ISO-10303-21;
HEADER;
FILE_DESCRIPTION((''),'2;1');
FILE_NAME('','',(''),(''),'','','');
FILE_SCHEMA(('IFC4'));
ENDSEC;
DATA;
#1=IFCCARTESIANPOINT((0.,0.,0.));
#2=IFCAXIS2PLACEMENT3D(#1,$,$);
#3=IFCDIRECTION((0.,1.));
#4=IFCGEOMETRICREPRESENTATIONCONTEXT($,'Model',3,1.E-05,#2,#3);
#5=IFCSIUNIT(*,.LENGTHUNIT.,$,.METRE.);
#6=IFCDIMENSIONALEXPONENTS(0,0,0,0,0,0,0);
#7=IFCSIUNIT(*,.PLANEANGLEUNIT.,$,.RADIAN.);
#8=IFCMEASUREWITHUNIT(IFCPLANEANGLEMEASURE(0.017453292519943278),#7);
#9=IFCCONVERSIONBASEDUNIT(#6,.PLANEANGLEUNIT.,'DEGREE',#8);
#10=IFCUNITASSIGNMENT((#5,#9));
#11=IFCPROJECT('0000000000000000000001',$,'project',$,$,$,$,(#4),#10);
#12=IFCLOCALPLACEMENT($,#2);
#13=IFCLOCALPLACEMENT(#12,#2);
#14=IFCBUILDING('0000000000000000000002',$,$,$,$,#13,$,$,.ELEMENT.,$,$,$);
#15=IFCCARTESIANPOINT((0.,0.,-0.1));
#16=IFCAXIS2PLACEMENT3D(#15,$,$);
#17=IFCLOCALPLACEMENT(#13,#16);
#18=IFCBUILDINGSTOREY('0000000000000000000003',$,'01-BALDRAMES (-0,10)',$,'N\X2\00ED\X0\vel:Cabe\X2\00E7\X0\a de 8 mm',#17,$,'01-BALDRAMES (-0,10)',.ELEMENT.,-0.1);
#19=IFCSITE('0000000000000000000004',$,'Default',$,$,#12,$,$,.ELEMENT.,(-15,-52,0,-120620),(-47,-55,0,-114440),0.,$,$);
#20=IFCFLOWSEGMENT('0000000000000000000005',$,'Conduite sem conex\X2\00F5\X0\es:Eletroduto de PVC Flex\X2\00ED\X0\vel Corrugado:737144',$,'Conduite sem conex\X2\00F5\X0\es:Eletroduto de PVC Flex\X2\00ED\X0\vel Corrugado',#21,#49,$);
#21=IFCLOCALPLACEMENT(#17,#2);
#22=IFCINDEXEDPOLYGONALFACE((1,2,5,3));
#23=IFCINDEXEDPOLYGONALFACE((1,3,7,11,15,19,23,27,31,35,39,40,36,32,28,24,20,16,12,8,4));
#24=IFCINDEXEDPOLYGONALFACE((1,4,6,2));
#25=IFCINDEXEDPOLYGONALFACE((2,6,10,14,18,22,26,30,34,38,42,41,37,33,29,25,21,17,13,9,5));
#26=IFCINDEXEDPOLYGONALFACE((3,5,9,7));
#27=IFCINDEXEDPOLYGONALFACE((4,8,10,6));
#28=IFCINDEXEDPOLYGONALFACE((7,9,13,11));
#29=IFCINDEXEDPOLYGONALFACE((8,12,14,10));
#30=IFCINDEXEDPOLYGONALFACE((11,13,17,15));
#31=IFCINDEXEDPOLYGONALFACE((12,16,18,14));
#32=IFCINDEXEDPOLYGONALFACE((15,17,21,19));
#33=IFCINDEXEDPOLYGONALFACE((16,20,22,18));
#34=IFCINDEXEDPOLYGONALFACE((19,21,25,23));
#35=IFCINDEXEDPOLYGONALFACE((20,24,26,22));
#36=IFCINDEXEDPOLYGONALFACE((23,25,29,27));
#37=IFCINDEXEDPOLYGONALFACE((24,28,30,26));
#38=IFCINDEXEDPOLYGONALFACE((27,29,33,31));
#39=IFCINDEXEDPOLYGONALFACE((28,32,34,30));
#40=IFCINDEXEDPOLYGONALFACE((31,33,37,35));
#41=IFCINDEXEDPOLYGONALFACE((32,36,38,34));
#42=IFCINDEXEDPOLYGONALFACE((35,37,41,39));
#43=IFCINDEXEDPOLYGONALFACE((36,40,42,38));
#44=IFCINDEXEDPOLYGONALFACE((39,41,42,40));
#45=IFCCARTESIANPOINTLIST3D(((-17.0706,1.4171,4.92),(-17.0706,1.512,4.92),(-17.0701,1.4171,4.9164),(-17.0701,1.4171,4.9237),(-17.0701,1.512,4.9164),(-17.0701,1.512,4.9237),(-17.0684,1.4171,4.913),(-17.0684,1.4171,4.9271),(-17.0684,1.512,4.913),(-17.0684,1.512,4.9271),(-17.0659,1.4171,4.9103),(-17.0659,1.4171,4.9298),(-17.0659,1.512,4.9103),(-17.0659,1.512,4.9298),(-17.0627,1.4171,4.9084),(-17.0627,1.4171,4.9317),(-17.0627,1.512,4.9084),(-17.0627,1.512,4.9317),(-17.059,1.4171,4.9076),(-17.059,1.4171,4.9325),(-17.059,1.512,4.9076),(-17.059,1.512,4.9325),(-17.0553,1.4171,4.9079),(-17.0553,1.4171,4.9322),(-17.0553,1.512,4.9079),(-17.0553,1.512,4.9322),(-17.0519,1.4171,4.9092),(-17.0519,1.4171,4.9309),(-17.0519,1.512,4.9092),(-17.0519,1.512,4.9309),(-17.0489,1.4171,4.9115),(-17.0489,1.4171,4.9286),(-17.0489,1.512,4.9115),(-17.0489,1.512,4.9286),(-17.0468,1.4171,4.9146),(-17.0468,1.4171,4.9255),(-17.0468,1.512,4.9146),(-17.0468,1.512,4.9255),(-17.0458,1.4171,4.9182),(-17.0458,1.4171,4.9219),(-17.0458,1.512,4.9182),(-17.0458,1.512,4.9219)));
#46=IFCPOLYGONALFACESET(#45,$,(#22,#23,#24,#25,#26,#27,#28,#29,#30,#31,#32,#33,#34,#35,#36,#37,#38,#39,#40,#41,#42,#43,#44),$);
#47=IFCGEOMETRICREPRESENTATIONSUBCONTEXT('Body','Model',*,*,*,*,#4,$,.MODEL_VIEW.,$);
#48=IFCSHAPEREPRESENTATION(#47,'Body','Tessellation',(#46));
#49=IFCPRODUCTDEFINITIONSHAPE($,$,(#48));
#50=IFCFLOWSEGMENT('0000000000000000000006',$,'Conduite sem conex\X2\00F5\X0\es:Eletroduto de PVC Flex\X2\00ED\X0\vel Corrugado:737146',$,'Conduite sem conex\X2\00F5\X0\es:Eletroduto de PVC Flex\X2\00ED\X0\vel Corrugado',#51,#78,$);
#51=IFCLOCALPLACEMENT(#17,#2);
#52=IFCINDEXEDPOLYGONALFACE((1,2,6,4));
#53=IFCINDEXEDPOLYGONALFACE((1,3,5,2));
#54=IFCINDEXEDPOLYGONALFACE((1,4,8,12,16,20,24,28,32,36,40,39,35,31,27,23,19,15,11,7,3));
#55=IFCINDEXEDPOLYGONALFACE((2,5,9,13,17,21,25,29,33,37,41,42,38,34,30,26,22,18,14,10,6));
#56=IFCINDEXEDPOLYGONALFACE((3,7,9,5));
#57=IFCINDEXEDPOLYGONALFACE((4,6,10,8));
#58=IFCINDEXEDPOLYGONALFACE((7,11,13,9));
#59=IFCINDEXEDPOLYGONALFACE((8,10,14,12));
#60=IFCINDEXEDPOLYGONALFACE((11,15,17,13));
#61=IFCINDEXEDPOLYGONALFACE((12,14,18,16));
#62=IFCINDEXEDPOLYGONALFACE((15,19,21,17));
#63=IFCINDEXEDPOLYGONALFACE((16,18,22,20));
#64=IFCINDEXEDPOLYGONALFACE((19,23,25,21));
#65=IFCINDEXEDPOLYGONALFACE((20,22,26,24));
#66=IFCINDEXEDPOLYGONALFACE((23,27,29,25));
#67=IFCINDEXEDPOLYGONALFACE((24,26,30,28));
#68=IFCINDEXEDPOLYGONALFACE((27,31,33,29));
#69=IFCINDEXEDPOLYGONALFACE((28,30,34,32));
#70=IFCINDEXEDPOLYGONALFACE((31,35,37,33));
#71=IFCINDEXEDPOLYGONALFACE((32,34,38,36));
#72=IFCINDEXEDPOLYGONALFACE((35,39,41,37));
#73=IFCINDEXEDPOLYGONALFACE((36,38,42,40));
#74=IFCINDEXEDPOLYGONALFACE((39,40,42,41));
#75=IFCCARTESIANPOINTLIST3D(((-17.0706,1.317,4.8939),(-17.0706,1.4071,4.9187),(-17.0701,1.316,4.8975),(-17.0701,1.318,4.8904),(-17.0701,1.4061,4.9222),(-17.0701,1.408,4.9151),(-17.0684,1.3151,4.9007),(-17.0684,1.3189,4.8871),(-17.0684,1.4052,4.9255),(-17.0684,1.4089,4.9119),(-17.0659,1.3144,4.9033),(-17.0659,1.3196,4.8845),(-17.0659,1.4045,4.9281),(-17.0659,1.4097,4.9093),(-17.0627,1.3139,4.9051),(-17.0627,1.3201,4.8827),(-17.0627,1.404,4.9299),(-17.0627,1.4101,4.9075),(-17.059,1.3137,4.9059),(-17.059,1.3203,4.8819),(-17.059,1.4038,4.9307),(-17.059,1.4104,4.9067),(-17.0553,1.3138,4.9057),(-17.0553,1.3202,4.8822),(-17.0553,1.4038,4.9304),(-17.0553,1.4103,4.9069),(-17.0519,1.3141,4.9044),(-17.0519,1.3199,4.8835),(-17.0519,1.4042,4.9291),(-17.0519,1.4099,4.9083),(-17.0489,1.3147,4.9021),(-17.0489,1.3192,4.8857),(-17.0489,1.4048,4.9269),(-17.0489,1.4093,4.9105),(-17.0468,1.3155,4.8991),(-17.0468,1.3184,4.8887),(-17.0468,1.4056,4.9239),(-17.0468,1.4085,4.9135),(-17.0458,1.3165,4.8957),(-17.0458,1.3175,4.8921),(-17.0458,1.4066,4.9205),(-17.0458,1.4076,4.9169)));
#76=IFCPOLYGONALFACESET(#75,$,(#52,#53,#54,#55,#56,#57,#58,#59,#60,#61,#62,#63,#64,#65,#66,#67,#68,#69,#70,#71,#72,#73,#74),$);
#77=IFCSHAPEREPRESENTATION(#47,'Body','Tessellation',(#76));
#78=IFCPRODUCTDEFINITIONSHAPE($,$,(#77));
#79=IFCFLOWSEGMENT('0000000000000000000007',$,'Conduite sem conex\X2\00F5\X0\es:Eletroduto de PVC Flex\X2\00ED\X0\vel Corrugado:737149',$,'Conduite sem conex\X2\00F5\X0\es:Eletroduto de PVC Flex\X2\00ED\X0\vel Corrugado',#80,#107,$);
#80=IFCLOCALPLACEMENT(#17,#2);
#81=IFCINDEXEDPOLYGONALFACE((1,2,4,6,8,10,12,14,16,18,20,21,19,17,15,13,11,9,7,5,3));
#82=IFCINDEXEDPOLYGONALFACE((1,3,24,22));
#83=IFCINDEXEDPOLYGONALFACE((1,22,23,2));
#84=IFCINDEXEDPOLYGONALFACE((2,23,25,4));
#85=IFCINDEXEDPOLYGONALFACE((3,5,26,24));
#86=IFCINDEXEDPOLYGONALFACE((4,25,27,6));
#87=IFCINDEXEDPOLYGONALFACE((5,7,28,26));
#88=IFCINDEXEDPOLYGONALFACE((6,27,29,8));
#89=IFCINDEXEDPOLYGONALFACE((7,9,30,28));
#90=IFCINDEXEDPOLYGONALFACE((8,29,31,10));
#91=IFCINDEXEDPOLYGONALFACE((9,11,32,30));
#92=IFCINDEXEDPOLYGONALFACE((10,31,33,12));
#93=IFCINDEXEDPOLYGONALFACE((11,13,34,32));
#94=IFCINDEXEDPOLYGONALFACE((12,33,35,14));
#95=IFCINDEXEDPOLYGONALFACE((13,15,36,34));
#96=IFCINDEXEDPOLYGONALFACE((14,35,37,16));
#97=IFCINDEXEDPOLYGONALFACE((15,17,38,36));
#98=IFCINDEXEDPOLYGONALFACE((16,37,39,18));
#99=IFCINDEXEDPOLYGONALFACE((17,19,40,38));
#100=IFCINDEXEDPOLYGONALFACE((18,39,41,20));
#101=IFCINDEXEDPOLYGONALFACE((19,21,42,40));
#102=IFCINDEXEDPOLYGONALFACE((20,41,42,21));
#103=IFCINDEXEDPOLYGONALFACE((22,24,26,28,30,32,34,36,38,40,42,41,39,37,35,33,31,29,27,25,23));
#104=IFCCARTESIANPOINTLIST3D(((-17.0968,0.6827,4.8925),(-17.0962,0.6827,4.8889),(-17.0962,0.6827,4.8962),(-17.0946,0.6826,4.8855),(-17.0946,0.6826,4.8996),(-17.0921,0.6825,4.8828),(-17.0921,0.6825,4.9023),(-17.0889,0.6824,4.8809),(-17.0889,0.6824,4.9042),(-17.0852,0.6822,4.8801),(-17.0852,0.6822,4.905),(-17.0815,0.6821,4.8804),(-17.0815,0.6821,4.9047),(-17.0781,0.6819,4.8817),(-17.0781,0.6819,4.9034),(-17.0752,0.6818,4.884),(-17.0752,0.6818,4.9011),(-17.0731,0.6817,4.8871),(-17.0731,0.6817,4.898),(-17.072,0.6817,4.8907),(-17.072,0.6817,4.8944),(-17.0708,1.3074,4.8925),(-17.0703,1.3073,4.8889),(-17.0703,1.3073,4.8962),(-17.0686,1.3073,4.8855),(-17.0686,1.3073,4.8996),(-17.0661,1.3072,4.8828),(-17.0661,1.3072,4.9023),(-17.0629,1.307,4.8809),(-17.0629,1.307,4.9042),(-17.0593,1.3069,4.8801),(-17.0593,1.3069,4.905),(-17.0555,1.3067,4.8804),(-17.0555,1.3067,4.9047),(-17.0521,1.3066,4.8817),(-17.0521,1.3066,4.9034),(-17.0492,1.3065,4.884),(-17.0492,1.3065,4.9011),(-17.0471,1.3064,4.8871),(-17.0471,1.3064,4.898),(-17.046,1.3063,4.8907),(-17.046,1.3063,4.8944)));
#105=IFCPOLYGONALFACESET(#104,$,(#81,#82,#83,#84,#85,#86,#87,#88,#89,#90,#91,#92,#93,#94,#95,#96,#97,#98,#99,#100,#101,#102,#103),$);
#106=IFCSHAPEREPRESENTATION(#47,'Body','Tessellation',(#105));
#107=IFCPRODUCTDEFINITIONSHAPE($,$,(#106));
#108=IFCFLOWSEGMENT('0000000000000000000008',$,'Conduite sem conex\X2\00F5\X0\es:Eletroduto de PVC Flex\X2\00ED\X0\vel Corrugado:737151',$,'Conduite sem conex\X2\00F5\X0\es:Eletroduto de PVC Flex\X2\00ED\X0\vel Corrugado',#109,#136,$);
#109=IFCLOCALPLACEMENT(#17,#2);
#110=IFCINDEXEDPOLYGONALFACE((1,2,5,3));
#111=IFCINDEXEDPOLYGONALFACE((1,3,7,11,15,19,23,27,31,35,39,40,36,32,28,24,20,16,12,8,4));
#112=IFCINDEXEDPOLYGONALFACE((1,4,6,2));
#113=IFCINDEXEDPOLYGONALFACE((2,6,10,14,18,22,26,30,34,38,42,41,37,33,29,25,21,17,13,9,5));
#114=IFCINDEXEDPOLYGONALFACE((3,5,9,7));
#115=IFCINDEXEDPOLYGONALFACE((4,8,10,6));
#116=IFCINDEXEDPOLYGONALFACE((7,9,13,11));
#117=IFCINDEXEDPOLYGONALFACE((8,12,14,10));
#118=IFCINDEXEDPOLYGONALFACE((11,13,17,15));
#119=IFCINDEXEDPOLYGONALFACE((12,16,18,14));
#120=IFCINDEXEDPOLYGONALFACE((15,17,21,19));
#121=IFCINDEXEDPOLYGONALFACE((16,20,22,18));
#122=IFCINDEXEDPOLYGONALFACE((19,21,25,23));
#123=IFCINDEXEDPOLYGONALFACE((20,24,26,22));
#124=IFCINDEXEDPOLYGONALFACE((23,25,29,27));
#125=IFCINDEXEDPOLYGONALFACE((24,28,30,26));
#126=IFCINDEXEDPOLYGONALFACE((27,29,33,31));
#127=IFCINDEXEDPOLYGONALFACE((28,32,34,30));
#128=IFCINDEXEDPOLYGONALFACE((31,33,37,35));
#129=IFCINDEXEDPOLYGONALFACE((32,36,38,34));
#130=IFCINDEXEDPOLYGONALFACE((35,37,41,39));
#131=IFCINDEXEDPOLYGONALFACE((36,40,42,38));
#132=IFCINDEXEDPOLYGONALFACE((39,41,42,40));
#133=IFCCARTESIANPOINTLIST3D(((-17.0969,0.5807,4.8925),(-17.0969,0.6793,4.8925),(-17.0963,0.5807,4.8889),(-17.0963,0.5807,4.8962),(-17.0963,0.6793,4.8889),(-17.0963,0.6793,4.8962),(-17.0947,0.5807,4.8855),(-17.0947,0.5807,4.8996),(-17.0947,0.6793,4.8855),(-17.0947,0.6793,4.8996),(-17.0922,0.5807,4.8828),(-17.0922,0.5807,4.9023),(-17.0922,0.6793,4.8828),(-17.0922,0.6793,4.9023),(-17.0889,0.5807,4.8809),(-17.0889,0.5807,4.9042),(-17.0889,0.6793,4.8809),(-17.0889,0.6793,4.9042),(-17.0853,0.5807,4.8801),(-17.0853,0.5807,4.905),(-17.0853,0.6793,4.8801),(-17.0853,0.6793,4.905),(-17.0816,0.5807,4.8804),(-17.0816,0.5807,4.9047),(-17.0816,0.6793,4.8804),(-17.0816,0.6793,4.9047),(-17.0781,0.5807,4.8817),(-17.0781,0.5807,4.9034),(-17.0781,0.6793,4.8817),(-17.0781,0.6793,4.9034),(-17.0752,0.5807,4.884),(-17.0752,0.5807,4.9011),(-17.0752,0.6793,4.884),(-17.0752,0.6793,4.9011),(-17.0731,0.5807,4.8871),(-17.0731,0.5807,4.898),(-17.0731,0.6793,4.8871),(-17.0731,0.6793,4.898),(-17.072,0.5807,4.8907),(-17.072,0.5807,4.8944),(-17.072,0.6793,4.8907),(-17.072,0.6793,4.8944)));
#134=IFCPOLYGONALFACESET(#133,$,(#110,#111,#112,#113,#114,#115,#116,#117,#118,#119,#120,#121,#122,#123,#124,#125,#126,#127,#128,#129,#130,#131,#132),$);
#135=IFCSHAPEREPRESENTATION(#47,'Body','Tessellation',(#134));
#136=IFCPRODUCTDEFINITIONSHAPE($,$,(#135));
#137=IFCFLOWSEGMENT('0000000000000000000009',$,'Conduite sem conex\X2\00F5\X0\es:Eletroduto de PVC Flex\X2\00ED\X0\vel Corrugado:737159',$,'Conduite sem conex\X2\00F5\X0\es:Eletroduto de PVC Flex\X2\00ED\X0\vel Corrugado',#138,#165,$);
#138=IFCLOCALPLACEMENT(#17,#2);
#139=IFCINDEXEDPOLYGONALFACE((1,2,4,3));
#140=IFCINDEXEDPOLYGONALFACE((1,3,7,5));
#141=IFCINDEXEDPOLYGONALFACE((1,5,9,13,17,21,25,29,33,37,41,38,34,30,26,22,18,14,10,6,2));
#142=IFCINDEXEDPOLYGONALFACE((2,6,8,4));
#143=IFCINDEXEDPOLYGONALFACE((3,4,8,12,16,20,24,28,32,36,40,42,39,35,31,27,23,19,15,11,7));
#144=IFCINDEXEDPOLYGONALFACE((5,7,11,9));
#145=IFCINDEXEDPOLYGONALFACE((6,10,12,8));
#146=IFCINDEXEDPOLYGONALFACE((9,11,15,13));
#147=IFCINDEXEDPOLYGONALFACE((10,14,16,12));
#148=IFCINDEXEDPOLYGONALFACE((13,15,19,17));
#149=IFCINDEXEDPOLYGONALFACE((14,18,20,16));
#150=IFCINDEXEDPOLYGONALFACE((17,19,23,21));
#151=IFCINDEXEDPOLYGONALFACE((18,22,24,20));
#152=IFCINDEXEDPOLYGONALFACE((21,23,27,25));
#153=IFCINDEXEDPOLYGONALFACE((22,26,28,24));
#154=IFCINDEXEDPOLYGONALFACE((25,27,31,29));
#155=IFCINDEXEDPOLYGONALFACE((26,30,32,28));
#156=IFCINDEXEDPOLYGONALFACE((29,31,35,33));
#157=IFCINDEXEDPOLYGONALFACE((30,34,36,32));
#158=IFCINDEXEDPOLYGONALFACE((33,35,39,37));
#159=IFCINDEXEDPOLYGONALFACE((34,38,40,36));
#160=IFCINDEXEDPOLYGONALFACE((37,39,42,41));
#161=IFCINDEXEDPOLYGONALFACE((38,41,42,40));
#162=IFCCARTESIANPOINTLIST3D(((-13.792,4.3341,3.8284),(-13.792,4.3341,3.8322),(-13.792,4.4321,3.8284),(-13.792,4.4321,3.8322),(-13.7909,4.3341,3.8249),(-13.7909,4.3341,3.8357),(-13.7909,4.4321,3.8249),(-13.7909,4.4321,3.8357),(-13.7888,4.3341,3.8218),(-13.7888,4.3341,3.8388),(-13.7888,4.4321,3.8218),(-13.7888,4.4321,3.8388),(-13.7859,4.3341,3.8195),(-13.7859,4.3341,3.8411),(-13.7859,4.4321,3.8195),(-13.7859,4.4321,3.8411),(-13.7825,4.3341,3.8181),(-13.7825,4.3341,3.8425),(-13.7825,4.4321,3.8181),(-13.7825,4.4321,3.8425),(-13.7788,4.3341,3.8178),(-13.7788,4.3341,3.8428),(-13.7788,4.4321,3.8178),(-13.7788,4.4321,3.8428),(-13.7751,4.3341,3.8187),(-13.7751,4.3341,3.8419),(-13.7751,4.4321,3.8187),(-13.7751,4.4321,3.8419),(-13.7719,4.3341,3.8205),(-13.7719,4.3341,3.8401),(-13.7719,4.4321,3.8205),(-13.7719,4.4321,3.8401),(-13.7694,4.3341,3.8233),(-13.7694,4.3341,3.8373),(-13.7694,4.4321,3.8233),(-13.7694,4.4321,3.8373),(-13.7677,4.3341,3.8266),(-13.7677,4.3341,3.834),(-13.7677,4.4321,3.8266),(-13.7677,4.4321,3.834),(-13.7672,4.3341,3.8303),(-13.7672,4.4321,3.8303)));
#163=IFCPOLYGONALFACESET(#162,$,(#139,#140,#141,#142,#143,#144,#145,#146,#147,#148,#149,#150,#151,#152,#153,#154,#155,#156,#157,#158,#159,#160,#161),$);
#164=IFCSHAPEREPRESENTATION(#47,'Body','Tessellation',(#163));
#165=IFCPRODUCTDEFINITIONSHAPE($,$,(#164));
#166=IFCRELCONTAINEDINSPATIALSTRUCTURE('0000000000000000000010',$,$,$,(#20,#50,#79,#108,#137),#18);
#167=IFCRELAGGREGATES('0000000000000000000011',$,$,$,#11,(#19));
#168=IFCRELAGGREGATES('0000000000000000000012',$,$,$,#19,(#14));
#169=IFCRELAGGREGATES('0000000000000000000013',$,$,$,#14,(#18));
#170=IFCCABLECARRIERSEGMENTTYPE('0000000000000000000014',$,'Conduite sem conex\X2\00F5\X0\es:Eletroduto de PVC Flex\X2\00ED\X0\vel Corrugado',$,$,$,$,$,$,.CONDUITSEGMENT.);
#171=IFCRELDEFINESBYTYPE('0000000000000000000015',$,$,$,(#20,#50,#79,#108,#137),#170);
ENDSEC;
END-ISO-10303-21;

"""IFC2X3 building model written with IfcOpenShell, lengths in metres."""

from ifc_helpers import new_model, entity, si_unit, converted_unit, direction, frame, frame_2d, origin, origin_2d_with_axis, place, context, subcontext, project, spatial, circle, extrude, type_object, element, save


model = new_model("IFC2X3")

# Units and contexts
model_context = context("Model", 3, precision=1e-05, world=origin(), true_north=direction((0.0, 1.0)))
body_context = subcontext(model_context, "Body", "Model", "MODEL_VIEW")
ifc_project = project(units=[si_unit("LENGTHUNIT", "METRE"), converted_unit("PLANEANGLEUNIT", "DEGREE", entity("IfcPlaneAngleMeasure", 0.017453292519943278), si_unit("PLANEANGLEUNIT", "RADIAN"), dimensions=[0, 0, 0, 0, 0, 0, 0])], contexts=[model_context])

# Site, building, storey
site_placement = place(None, origin())
site = spatial("IfcSite", under=ifc_project, at=site_placement, Name="Default", CompositionType="ELEMENT", RefLatitude=(-15, -52, 0, -120620), RefLongitude=(-47, -55, 0, -114440), RefElevation=0.0)
building_placement = place(site_placement, origin())
building = spatial("IfcBuilding", under=site, at=building_placement, CompositionType="ELEMENT")
storey_placement = place(building_placement, frame((0.0, 0.0, -0.1)))
storey = spatial("IfcBuildingStorey", under=building, at=storey_placement, Name="01-BALDRAMES (-0,10)", ObjectType="Nível:Cabeça de 8 mm", LongName="01-BALDRAMES (-0,10)", CompositionType="ELEMENT", Elevation=-0.1)

# Flow segments
cable_carrier_segment_type = type_object("IfcCableCarrierSegmentType", Name="Conduite sem conexões:Eletroduto de PVC Flexível Corrugado", PredefinedType="CONDUITSEGMENT")
flow_segment_1_placement = place(storey_placement, origin())
element("IfcFlowSegment", 1, at=flow_segment_1_placement, inside=storey, type_object=cable_carrier_segment_type, Name="Conduite sem conexões:Eletroduto de PVC Flexível Corrugado:737144", ObjectType="Conduite sem conexões:Eletroduto de PVC Flexível Corrugado", context=body_context, shape_type="SweptSolid", body=[
    extrude(circle(Radius=0.0125, at=frame_2d((0.0, 0.0), x_axis=(1.0, 0.0))), frame((-17.0581, 1.4171, 4.92), z_axis=(0.0, 1.0, 0.0), x_axis=(-1.0, 0.0, 0.0)), (0.0, 0.0, 1.0), 0.0949),
])
flow_segment_2_placement = place(storey_placement, origin())
element("IfcFlowSegment", 2, at=flow_segment_2_placement, inside=storey, type_object=cable_carrier_segment_type, Name="Conduite sem conexões:Eletroduto de PVC Flexível Corrugado:737146", ObjectType="Conduite sem conexões:Eletroduto de PVC Flexível Corrugado", context=body_context, shape_type="SweptSolid", body=[
    extrude(circle(Radius=0.0125, at=frame_2d((0.0, 0.0), x_axis=(1.0, 0.0))), frame((-17.0581, 1.317, 4.8939), z_axis=(0.0, 0.964205, 0.265156), x_axis=(-1.0, 0.0, 0.0)), (0.0, 0.0, 1.0), 0.0934),
])
flow_segment_3_placement = place(storey_placement, origin())
element("IfcFlowSegment", 3, at=flow_segment_3_placement, inside=storey, type_object=cable_carrier_segment_type, Name="Conduite sem conexões:Eletroduto de PVC Flexível Corrugado:737149", ObjectType="Conduite sem conexões:Eletroduto de PVC Flexível Corrugado", context=body_context, shape_type="SweptSolid", body=[
    extrude(circle(Radius=0.0125, at=frame_2d((0.0, 0.0), x_axis=(1.0, 0.0))), frame((-17.0843, 0.6822, 4.8925), z_axis=(0.041566, 0.999136, 0.0), x_axis=(-0.999136, 0.041566, 0.0)), (0.0, 0.0, 1.0), 0.6252),
])
flow_segment_4_placement = place(storey_placement, origin())
element("IfcFlowSegment", 4, at=flow_segment_4_placement, inside=storey, type_object=cable_carrier_segment_type, Name="Conduite sem conexões:Eletroduto de PVC Flexível Corrugado:737151", ObjectType="Conduite sem conexões:Eletroduto de PVC Flexível Corrugado", context=body_context, shape_type="SweptSolid", body=[
    extrude(circle(Radius=0.0125, at=frame_2d((0.0, 0.0), x_axis=(1.0, 0.0))), frame((-17.0844, 0.5807, 4.8925), z_axis=(0.0, 1.0, 0.0), x_axis=(-1.0, 0.0, 0.0)), (0.0, 0.0, 1.0), 0.0985),
])
flow_segment_5_placement = place(storey_placement, origin())
element("IfcFlowSegment", 5, at=flow_segment_5_placement, inside=storey, type_object=cable_carrier_segment_type, Name="Conduite sem conexões:Eletroduto de PVC Flexível Corrugado:737159", ObjectType="Conduite sem conexões:Eletroduto de PVC Flexível Corrugado", context=body_context, shape_type="SweptSolid", body=[
    extrude(circle(Radius=0.0125, at=origin_2d_with_axis()), frame((-13.7797, 4.3341, 3.8303), z_axis=(0.0, 1.0, 0.0), x_axis=(1.0, 0.0, 0.0)), (0.0, 0.0, 1.0), 0.098),
])

save(model, "model.ifc")
